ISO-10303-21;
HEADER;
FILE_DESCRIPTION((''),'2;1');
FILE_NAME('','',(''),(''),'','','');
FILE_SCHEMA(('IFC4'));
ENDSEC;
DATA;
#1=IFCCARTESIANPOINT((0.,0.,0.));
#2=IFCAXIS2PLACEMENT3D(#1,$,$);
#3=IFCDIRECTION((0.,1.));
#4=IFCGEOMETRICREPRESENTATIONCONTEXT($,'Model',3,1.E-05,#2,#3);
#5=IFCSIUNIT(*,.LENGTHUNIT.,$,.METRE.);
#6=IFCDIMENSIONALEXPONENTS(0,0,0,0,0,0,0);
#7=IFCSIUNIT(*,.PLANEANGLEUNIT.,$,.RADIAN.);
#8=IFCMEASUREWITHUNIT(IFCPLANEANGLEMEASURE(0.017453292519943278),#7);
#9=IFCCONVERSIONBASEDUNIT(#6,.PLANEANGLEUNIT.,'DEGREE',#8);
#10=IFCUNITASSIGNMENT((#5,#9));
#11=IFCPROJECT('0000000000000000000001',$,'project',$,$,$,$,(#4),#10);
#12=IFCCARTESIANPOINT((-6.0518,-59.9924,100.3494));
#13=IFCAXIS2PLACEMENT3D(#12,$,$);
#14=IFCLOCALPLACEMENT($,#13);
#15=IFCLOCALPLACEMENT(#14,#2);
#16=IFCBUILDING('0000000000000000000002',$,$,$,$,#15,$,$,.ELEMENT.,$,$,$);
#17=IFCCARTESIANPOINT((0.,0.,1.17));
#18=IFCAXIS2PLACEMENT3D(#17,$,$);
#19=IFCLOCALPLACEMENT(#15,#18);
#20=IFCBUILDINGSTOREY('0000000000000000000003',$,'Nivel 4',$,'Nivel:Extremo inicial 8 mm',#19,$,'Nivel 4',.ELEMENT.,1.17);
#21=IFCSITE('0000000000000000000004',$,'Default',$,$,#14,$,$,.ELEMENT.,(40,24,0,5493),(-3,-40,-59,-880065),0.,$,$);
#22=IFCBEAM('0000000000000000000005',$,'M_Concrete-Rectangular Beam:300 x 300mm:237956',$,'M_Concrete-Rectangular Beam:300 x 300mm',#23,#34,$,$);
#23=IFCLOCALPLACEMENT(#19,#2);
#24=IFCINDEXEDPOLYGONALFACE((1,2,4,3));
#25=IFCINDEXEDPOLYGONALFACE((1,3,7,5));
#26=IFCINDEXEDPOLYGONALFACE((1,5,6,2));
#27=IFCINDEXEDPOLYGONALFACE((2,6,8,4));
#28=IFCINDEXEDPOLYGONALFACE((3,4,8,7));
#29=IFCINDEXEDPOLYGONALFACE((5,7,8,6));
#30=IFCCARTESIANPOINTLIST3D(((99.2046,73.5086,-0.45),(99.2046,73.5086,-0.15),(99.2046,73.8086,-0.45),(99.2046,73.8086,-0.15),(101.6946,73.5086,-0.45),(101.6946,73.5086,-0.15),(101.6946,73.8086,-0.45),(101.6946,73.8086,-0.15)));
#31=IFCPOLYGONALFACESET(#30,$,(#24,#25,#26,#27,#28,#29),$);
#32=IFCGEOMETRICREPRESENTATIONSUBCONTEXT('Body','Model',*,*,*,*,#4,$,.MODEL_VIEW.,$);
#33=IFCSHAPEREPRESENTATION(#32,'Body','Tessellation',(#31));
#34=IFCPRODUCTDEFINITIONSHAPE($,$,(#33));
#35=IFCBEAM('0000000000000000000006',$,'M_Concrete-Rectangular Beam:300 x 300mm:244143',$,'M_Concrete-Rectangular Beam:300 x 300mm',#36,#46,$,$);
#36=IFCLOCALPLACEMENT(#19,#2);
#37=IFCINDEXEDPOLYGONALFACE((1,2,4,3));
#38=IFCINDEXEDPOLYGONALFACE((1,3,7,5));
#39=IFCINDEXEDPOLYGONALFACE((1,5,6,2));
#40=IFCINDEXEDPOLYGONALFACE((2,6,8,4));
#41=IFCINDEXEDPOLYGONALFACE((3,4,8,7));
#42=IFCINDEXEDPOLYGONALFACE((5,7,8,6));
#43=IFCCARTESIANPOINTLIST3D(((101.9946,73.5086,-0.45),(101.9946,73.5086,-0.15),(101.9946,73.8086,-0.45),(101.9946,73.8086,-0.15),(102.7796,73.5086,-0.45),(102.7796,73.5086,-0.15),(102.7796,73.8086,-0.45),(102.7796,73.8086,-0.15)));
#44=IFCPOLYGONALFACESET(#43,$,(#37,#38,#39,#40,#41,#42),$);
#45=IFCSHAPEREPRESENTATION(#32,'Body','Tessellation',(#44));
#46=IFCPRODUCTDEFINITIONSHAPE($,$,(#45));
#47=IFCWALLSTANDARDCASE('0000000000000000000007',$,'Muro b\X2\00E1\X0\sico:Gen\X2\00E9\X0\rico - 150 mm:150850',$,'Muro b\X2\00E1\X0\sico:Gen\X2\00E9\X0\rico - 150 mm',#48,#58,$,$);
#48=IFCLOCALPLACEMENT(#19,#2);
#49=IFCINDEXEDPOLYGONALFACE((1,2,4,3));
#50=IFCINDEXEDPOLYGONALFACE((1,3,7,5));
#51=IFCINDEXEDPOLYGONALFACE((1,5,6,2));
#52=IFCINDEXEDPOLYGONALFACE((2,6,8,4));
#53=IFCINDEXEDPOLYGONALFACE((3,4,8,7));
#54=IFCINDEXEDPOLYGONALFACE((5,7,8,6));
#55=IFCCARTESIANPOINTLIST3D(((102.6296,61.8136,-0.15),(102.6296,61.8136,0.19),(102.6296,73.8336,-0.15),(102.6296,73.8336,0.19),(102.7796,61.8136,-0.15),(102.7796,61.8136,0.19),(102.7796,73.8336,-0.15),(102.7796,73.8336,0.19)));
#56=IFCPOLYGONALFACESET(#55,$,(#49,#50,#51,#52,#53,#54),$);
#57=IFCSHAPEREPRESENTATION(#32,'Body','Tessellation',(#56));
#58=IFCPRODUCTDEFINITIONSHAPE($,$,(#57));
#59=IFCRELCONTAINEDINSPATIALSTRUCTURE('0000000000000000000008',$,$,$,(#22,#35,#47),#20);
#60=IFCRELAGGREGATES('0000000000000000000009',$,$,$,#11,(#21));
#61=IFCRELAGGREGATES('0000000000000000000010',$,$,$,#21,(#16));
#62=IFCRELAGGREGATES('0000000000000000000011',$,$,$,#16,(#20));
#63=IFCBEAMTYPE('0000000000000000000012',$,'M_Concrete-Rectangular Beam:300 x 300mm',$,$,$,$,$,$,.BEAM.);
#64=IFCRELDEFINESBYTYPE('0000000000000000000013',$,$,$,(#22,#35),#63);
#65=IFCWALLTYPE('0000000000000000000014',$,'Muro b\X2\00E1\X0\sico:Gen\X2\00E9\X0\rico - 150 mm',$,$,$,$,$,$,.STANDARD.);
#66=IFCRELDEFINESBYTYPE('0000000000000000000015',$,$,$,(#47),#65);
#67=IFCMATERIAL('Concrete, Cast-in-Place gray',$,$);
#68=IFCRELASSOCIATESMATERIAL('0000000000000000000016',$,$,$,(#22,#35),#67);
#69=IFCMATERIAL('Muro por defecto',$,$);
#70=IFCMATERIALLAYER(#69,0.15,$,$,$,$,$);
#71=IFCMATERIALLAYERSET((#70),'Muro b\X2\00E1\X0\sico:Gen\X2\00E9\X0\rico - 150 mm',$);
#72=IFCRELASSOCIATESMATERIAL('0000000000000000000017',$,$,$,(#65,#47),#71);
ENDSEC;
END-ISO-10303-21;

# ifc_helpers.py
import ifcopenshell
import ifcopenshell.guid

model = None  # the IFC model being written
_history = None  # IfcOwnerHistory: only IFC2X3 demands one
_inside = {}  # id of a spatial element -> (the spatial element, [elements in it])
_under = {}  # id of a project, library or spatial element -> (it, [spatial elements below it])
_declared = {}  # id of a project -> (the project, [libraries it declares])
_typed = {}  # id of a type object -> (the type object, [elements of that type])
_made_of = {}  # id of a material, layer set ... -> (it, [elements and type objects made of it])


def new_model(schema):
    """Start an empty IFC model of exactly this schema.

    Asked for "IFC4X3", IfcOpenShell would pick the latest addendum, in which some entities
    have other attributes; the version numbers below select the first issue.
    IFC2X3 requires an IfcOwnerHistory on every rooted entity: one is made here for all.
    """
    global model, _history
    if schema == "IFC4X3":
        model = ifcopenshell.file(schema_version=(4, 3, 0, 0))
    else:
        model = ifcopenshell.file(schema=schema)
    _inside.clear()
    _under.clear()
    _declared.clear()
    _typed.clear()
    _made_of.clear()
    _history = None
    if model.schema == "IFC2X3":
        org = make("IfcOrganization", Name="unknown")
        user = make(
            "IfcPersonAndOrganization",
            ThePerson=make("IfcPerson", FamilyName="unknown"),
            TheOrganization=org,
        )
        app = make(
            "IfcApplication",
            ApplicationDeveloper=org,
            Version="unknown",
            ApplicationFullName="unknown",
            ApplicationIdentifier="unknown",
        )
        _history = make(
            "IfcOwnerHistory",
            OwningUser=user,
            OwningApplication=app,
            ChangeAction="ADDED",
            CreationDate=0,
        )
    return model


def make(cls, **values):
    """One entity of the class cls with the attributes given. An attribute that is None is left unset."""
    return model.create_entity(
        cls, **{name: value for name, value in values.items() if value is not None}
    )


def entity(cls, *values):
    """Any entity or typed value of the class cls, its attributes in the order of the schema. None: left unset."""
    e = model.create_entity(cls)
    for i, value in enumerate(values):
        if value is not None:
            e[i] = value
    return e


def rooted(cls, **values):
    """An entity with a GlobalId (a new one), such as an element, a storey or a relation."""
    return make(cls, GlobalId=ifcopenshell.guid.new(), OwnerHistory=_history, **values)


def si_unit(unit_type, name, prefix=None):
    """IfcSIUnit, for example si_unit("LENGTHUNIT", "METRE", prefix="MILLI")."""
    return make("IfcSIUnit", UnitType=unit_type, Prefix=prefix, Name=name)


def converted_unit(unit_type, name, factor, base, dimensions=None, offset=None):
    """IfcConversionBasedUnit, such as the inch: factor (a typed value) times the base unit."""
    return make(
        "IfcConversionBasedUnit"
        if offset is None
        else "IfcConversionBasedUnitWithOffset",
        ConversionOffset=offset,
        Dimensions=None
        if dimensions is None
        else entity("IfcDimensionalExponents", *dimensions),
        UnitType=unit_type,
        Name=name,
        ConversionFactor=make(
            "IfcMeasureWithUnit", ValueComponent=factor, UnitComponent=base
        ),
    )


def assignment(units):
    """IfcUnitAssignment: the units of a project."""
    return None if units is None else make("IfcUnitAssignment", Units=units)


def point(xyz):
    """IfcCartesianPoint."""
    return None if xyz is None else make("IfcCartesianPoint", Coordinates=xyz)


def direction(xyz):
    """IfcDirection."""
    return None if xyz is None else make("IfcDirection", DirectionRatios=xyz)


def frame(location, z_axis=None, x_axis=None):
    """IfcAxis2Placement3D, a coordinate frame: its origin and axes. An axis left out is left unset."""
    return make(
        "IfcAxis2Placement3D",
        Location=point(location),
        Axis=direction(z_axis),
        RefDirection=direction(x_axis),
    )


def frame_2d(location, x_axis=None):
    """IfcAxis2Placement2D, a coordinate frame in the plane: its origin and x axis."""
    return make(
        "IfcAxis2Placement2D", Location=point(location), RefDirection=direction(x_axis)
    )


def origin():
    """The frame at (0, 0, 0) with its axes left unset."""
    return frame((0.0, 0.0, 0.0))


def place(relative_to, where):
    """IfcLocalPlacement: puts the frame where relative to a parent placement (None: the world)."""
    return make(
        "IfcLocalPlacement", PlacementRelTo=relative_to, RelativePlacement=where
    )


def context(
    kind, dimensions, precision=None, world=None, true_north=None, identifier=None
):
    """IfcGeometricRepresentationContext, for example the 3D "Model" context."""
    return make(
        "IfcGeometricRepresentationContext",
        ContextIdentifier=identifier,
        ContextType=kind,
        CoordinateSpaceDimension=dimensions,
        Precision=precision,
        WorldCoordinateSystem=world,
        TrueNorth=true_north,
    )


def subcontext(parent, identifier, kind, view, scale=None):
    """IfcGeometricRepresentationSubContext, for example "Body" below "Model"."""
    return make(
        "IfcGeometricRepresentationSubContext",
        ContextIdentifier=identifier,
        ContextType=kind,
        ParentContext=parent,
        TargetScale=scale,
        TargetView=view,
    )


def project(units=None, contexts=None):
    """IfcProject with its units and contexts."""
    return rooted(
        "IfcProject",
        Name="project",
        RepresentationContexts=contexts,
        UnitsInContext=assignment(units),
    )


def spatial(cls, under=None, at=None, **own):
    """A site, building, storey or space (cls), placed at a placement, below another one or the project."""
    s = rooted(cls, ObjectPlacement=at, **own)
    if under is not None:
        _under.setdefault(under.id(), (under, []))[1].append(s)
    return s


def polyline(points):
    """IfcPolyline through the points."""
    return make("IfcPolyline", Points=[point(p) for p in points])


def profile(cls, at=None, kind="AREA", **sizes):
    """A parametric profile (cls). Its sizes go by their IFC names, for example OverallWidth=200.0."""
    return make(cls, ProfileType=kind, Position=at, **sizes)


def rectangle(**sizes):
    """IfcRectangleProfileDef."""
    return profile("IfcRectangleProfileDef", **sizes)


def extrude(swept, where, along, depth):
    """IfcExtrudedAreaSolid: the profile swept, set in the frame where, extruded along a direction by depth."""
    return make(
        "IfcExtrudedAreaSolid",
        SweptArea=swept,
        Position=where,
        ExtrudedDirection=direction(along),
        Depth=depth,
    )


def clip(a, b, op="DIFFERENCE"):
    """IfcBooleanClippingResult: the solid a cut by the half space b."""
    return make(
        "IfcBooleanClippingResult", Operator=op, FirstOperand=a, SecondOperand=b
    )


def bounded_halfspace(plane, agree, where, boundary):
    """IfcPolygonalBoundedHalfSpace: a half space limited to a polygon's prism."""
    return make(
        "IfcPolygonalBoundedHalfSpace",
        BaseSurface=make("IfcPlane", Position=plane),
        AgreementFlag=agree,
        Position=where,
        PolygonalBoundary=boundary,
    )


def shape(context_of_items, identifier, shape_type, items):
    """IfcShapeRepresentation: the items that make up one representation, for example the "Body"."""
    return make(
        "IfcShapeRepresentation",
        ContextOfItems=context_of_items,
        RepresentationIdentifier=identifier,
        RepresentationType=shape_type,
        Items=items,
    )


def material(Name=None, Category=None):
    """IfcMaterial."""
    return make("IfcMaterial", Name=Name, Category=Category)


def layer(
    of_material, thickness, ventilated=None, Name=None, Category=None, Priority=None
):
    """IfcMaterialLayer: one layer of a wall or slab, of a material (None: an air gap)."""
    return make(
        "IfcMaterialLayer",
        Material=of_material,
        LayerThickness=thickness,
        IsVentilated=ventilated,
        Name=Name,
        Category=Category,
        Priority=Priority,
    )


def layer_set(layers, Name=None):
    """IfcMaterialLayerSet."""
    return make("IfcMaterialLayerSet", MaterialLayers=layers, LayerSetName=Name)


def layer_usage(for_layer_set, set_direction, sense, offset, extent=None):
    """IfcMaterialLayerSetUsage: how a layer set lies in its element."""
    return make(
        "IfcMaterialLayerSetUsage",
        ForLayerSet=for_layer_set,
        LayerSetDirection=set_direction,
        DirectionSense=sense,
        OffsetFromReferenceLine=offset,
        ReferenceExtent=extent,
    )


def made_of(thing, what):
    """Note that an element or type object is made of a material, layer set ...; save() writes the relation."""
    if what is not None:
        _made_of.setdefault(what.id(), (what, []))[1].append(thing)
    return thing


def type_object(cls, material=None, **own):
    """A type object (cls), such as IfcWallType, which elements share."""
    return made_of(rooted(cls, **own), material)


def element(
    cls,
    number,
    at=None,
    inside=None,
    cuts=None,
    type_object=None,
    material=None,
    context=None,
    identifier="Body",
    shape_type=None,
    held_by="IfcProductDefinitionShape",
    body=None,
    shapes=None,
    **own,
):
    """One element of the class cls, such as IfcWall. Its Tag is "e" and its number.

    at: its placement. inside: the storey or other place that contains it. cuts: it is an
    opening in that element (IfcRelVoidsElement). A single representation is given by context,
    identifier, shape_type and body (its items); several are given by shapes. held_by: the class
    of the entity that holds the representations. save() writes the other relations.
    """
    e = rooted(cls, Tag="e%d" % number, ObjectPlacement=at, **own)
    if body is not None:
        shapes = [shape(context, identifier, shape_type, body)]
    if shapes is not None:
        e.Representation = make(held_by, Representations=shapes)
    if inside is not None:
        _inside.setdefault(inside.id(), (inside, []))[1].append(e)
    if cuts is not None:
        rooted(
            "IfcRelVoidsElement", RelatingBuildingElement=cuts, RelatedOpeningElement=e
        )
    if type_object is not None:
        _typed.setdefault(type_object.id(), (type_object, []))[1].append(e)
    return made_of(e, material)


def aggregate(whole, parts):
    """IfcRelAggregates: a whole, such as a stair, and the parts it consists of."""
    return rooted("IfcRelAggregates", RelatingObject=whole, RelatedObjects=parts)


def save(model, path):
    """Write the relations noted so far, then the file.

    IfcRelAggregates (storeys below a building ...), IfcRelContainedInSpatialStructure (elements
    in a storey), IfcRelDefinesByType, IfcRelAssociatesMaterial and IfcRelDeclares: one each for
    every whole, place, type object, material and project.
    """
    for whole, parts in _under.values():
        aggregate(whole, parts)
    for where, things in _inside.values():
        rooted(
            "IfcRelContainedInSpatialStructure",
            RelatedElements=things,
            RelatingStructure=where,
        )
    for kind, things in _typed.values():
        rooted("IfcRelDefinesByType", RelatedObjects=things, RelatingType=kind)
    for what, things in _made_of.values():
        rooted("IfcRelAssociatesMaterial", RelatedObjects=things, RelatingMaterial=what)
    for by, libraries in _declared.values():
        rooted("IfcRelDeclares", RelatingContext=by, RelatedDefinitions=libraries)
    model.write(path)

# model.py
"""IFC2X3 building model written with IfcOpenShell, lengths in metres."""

from ifc_helpers import new_model, entity, si_unit, converted_unit, direction, frame, frame_2d, origin, place, context, subcontext, project, spatial, polyline, rectangle, extrude, clip, bounded_halfspace, material, layer, layer_set, layer_usage, type_object, element, save


model = new_model("IFC2X3")

# Units and contexts
model_context = context("Model", 3, precision=1e-05, world=origin(), true_north=direction((0.0, 1.0)))
body_context = subcontext(model_context, "Body", "Model", "MODEL_VIEW")
ifc_project = project(units=[si_unit("LENGTHUNIT", "METRE"), converted_unit("PLANEANGLEUNIT", "DEGREE", entity("IfcPlaneAngleMeasure", 0.017453292519943278), si_unit("PLANEANGLEUNIT", "RADIAN"), dimensions=[0, 0, 0, 0, 0, 0, 0])], contexts=[model_context])

# Site, building, storey
site_placement = place(None, frame((-6.0518, -59.9924, 100.3494)))
site = spatial("IfcSite", under=ifc_project, at=site_placement, Name="Default", CompositionType="ELEMENT", RefLatitude=(40, 24, 0, 5493), RefLongitude=(-3, -40, -59, -880065), RefElevation=0.0)
building_placement = place(site_placement, origin())
building = spatial("IfcBuilding", under=site, at=building_placement, CompositionType="ELEMENT")
storey_placement = place(building_placement, frame((0.0, 0.0, 1.17)))
storey = spatial("IfcBuildingStorey", under=building, at=storey_placement, Name="Nivel 4", ObjectType="Nivel:Extremo inicial 8 mm", LongName="Nivel 4", CompositionType="ELEMENT", Elevation=1.17)

# Beams
ifc_material_1 = material(Name="Concrete, Cast-in-Place gray")
beam_type = type_object("IfcBeamType", Name="M_Concrete-Rectangular Beam:300 x 300mm", PredefinedType="BEAM")
beam_1_placement = place(storey_placement, frame((101.8446, 73.6586, 0.0), z_axis=(0.0, 0.0, 1.0), x_axis=(-1.0, 0.0, 0.0)))
element("IfcBeam", 1, at=beam_1_placement, inside=storey, type_object=beam_type, material=ifc_material_1, Name="M_Concrete-Rectangular Beam:300 x 300mm:237956", ObjectType="M_Concrete-Rectangular Beam:300 x 300mm", context=body_context, shape_type="SweptSolid", body=[
    extrude(rectangle(XDim=0.3, YDim=0.3, at=frame_2d((0.0, 0.0), x_axis=(1.0, 0.0))), frame((0.15, 0.0, -0.3), z_axis=(1.0, 0.0, 0.0), x_axis=(0.0, 0.0, -1.0)), (0.0, 0.0, 1.0), 2.49),
])
beam_2_placement = place(storey_placement, frame((101.8446, 73.6586, 0.0)))
element("IfcBeam", 2, at=beam_2_placement, inside=storey, type_object=beam_type, material=ifc_material_1, Name="M_Concrete-Rectangular Beam:300 x 300mm:244143", ObjectType="M_Concrete-Rectangular Beam:300 x 300mm", context=body_context, shape_type="SweptSolid", body=[
    extrude(rectangle(XDim=0.3, YDim=0.3, at=frame_2d((0.0, 0.0), x_axis=(1.0, 0.0))), frame((0.15, 0.0, -0.3), z_axis=(1.0, 0.0, 0.0), x_axis=(0.0, 0.0, -1.0)), (0.0, 0.0, 1.0), 0.785),
])

# Wall
ifc_material_2 = material(Name="Muro por defecto")
ifc_layer = layer(ifc_material_2, 0.15)
ifc_layer_set = layer_set([ifc_layer], Name="Muro básico:Genérico - 150 mm")
ifc_layer_usage = layer_usage(ifc_layer_set, "AXIS2", "NEGATIVE", 0.075)
wall_type = type_object("IfcWallType", Name="Muro básico:Genérico - 150 mm", PredefinedType="STANDARD", material=ifc_layer_set)
wall_placement = place(storey_placement, frame((102.7046, 73.8336, -0.15), z_axis=(0.0, 0.0, 1.0), x_axis=(0.0, -1.0, 0.0)))
element("IfcWallStandardCase", 3, at=wall_placement, inside=storey, type_object=wall_type, material=ifc_layer_usage, Name="Muro básico:Genérico - 150 mm:150850", ObjectType="Muro básico:Genérico - 150 mm", context=body_context, shape_type="Clipping", body=[
    clip(extrude(rectangle(XDim=12.02, YDim=0.15, at=frame_2d((6.01, 0.0), x_axis=(-1.0, 0.0))), origin(), (0.0, 0.0, 1.0), 0.34), bounded_halfspace(frame((0.0, -0.075, 0.34), z_axis=(0.0, 0.0, -1.0), x_axis=(1.0, 0.0, 0.0)), True, frame((0.0, -0.075, 0.34), z_axis=(0.0, 0.0, -1.0), x_axis=(1.0, 0.0, 0.0)), polyline([(0.0, 0.0), (0.0, -0.15), (12.02, -0.15), (12.02, 0.0), (0.0, 0.0)]))),
])

save(model, "model.ifc")
